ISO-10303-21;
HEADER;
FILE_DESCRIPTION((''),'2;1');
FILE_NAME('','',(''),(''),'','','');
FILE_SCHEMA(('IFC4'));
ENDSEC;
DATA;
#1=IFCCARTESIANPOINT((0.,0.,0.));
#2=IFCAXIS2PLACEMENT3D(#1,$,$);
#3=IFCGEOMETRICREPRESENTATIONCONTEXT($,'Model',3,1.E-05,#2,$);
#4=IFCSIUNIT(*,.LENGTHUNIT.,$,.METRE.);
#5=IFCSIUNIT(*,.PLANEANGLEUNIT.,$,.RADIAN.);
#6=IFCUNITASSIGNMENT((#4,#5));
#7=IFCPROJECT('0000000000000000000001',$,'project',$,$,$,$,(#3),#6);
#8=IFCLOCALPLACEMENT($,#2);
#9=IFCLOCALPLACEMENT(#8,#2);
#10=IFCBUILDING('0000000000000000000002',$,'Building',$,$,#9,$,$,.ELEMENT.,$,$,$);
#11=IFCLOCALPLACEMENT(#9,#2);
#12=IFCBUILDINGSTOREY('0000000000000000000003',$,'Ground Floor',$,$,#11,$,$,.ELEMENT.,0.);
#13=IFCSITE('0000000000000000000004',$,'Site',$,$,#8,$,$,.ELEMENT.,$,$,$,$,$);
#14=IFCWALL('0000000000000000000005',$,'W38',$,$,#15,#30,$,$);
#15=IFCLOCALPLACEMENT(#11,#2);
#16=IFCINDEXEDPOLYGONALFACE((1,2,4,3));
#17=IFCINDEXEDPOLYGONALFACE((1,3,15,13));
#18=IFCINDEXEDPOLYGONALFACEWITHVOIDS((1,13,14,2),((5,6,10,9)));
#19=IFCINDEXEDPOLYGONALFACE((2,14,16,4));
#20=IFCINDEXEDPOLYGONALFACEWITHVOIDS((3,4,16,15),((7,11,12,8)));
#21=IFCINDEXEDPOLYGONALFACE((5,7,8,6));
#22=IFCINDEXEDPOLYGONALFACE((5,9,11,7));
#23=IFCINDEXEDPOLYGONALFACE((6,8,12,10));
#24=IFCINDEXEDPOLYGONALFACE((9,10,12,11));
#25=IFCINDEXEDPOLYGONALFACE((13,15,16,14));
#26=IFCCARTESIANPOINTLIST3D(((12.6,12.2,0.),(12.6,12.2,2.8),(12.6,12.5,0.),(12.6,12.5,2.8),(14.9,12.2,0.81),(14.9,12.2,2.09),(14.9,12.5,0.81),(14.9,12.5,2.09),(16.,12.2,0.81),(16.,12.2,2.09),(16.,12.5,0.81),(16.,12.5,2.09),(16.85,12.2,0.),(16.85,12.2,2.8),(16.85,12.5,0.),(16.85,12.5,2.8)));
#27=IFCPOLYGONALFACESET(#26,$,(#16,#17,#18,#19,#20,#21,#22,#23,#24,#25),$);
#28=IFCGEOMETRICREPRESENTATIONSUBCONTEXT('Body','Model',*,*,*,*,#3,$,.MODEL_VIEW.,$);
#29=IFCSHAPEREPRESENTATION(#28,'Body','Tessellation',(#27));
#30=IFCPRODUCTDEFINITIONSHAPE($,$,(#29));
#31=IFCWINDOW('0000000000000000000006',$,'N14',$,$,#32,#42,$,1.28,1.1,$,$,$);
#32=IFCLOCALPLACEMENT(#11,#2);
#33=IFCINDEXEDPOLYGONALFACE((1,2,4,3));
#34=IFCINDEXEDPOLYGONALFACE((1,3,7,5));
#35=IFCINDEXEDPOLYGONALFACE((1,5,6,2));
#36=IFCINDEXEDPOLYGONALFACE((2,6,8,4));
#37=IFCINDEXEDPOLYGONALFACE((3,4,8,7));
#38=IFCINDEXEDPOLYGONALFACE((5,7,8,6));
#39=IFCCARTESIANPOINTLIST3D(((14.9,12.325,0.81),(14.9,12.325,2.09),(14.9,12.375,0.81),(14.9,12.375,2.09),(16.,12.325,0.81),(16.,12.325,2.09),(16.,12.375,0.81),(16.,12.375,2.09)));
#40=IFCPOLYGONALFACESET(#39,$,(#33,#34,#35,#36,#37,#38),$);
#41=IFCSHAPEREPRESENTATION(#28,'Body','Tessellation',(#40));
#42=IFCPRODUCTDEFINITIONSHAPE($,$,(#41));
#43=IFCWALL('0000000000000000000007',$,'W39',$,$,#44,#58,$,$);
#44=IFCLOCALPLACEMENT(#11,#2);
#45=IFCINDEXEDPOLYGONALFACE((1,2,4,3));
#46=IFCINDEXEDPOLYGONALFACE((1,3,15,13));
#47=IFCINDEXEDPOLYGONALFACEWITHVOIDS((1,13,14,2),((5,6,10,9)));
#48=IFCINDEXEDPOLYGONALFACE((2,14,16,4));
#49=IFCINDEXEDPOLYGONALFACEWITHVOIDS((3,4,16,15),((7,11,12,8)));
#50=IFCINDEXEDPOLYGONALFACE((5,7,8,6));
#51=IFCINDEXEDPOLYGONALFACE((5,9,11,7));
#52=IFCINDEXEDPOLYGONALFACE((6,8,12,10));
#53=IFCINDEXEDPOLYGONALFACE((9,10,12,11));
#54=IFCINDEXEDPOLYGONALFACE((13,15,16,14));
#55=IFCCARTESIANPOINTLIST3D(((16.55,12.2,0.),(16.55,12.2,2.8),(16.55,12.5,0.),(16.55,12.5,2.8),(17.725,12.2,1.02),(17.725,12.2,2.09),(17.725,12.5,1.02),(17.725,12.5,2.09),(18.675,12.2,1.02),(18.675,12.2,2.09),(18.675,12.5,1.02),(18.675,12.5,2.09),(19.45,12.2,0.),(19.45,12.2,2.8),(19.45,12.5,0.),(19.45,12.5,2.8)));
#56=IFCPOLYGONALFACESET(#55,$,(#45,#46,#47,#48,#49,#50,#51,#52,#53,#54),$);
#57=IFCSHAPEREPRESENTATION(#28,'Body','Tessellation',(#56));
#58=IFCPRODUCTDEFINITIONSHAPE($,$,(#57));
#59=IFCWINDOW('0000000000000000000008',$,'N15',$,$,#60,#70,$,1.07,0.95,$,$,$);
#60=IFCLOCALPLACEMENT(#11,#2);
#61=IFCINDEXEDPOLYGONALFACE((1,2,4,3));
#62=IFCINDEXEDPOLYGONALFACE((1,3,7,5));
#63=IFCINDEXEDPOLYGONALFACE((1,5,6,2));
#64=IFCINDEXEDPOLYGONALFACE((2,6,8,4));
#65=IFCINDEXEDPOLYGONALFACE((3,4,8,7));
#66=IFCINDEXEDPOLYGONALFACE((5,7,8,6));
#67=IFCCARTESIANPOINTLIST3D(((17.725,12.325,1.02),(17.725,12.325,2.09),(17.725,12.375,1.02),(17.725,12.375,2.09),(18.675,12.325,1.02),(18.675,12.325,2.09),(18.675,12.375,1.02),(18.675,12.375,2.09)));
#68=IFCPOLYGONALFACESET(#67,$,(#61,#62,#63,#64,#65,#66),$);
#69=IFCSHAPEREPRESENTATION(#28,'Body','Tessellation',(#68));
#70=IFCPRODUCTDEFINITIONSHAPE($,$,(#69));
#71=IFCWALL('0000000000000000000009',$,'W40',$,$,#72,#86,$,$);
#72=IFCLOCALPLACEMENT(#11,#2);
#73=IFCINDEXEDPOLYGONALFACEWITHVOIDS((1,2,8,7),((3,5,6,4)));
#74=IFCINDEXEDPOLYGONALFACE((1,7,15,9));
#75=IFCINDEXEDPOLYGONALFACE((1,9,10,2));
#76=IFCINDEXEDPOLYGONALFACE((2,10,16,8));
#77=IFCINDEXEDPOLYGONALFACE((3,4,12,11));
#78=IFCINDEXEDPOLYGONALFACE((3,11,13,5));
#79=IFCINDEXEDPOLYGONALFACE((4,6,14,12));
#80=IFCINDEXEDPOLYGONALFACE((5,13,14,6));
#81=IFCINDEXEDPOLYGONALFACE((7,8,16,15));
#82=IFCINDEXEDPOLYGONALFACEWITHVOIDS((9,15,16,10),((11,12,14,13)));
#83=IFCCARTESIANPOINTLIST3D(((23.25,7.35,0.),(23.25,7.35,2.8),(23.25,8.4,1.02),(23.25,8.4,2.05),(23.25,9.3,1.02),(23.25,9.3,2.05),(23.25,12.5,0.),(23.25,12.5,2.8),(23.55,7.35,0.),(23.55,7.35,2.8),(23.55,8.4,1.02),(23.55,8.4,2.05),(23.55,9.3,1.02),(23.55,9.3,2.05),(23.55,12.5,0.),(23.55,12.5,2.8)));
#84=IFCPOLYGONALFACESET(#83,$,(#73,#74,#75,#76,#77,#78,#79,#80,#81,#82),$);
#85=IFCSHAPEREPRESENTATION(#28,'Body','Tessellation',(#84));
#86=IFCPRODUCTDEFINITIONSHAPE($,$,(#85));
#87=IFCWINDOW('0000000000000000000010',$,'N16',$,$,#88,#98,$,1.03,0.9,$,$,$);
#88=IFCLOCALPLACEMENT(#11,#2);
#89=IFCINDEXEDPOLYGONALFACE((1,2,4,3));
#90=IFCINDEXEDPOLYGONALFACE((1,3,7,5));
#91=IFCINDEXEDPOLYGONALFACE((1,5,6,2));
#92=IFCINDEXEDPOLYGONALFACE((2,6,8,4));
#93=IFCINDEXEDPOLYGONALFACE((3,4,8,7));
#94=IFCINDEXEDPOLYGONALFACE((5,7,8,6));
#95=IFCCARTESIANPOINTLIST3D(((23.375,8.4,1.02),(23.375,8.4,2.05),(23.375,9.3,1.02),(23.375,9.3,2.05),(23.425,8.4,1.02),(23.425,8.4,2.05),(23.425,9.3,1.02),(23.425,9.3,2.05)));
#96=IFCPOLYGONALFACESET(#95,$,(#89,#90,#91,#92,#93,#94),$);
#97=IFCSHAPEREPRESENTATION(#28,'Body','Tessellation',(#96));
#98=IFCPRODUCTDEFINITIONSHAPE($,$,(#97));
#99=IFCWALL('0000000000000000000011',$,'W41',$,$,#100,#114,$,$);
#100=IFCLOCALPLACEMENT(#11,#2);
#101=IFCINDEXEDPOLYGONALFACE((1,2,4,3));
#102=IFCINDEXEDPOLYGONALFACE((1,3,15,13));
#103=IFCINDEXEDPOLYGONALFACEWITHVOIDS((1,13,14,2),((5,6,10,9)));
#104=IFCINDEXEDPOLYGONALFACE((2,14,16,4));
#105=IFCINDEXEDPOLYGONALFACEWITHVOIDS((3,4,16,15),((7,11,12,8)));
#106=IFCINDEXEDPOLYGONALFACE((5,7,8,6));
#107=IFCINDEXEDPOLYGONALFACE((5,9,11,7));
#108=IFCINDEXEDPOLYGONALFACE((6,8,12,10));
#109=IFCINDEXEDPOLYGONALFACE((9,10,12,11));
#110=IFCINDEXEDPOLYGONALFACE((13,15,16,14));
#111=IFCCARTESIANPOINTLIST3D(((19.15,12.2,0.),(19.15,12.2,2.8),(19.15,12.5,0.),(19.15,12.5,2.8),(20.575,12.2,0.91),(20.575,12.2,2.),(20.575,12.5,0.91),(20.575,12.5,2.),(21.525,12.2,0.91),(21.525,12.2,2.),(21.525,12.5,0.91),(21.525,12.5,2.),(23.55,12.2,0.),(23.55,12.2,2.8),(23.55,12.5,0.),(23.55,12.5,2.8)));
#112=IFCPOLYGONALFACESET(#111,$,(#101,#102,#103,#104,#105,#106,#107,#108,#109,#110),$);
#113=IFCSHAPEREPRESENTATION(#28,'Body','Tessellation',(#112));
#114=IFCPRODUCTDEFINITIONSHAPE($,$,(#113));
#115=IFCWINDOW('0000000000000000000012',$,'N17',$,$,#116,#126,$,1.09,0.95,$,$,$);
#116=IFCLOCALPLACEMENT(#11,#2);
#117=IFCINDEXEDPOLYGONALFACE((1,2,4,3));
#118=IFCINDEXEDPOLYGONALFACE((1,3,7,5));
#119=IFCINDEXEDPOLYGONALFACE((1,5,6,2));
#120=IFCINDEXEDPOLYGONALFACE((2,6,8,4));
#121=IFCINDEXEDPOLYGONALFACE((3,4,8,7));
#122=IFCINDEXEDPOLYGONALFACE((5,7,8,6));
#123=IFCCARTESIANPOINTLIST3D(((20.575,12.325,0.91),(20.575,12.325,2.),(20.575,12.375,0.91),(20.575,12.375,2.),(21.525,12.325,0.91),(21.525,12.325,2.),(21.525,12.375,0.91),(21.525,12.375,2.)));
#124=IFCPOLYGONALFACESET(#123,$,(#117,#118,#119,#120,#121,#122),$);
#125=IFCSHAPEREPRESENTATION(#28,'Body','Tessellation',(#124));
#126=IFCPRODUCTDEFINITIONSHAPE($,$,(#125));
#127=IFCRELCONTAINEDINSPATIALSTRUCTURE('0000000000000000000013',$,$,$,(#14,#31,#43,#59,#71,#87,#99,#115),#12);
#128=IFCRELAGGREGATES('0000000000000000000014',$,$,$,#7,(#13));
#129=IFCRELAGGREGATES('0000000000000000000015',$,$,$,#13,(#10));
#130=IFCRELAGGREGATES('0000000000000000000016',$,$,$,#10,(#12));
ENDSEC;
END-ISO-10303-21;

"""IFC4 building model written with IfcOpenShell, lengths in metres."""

from ifc_helpers import new_model, si_unit, frame, frame_2d, origin, origin_2d, place, context, subcontext, project, spatial, rectangle, extrude, element, fill, save


model = new_model("IFC4")

# Units and contexts
model_context = context("Model", 3, precision=1e-05, world=origin())
body_context = subcontext(model_context, "Body", "Model", "MODEL_VIEW")
ifc_project = project(units=[si_unit("LENGTHUNIT", "METRE"), si_unit("PLANEANGLEUNIT", "RADIAN")], contexts=[model_context])

# Site, building, storey
site_placement = place(None, origin())
site = spatial("IfcSite", under=ifc_project, at=site_placement, Name="Site", CompositionType="ELEMENT")
building_placement = place(site_placement, origin())
building = spatial("IfcBuilding", under=site, at=building_placement, Name="Building", CompositionType="ELEMENT")
storey_placement = place(building_placement, origin())
storey = spatial("IfcBuildingStorey", under=building, at=storey_placement, Name="Ground Floor", CompositionType="ELEMENT", Elevation=0.0)

# Walls, openings, windows
wall_1_placement = place(storey_placement, frame((12.75, 12.35, 0.0), x_axis=(1.0, 0.0, 0.0)))
wall_1 = element("IfcWall", 1, at=wall_1_placement, inside=storey, Name="W38", context=body_context, shape_type="SweptSolid", body=[
    extrude(rectangle(XDim=4.25, YDim=0.3, at=frame_2d((1.975, 0.0))), origin(), (0.0, 0.0, 1.0), 2.8),
])
opening_1_placement = place(wall_1_placement, frame((2.7, 0.0, 0.81)))
opening_1 = element("IfcOpeningElement", 2, at=opening_1_placement, cuts=wall_1, context=body_context, shape_type="SweptSolid", body=[
    extrude(rectangle(XDim=1.1, YDim=0.4, at=origin_2d()), origin(), (0.0, 0.0, 1.0), 1.28),
])
window_1_placement = place(opening_1_placement, origin())
window_1 = element("IfcWindow", 3, at=window_1_placement, inside=storey, Name="N14", OverallHeight=1.28, OverallWidth=1.1, context=body_context, shape_type="SweptSolid", body=[
    extrude(rectangle(XDim=1.1, YDim=0.05, at=origin_2d()), origin(), (0.0, 0.0, 1.0), 1.28),
])
fill(opening_1, window_1)
wall_2_placement = place(storey_placement, frame((16.7, 12.35, 0.0), x_axis=(1.0, 0.0, 0.0)))
wall_2 = element("IfcWall", 4, at=wall_2_placement, inside=storey, Name="W39", context=body_context, shape_type="SweptSolid", body=[
    extrude(rectangle(XDim=2.9, YDim=0.3, at=frame_2d((1.3, 0.0))), origin(), (0.0, 0.0, 1.0), 2.8),
])
opening_2_placement = place(wall_2_placement, frame((1.5, 0.0, 1.02)))
opening_2 = element("IfcOpeningElement", 5, at=opening_2_placement, cuts=wall_2, context=body_context, shape_type="SweptSolid", body=[
    extrude(rectangle(XDim=0.95, YDim=0.4, at=origin_2d()), origin(), (0.0, 0.0, 1.0), 1.07),
])
window_2_placement = place(opening_2_placement, origin())
window_2 = element("IfcWindow", 6, at=window_2_placement, inside=storey, Name="N15", OverallHeight=1.07, OverallWidth=0.95, context=body_context, shape_type="SweptSolid", body=[
    extrude(rectangle(XDim=0.95, YDim=0.05, at=origin_2d()), origin(), (0.0, 0.0, 1.0), 1.07),
])
fill(opening_2, window_2)
wall_3_placement = place(storey_placement, frame((23.4, 7.5, 0.0), x_axis=(0.0, 1.0, 0.0)))
wall_3 = element("IfcWall", 7, at=wall_3_placement, inside=storey, Name="W40", context=body_context, shape_type="SweptSolid", body=[
    extrude(rectangle(XDim=5.15, YDim=0.3, at=frame_2d((2.425, 0.0))), origin(), (0.0, 0.0, 1.0), 2.8),
])
opening_3_placement = place(wall_3_placement, frame((1.35, 0.0, 1.02)))
opening_3 = element("IfcOpeningElement", 8, at=opening_3_placement, cuts=wall_3, context=body_context, shape_type="SweptSolid", body=[
    extrude(rectangle(XDim=0.9, YDim=0.4, at=origin_2d()), origin(), (0.0, 0.0, 1.0), 1.03),
])
window_3_placement = place(opening_3_placement, origin())
window_3 = element("IfcWindow", 9, at=window_3_placement, inside=storey, Name="N16", OverallHeight=1.03, OverallWidth=0.9, context=body_context, shape_type="SweptSolid", body=[
    extrude(rectangle(XDim=0.9, YDim=0.05, at=origin_2d()), origin(), (0.0, 0.0, 1.0), 1.03),
])
fill(opening_3, window_3)
wall_4_placement = place(storey_placement, frame((19.3, 12.35, 0.0), x_axis=(1.0, 0.0, 0.0)))
wall_4 = element("IfcWall", 10, at=wall_4_placement, inside=storey, Name="W41", context=body_context, shape_type="SweptSolid", body=[
    extrude(rectangle(XDim=4.4, YDim=0.3, at=frame_2d((2.05, 0.0))), origin(), (0.0, 0.0, 1.0), 2.8),
])
opening_4_placement = place(wall_4_placement, frame((1.75, 0.0, 0.91)))
opening_4 = element("IfcOpeningElement", 11, at=opening_4_placement, cuts=wall_4, context=body_context, shape_type="SweptSolid", body=[
    extrude(rectangle(XDim=0.95, YDim=0.4, at=origin_2d()), origin(), (0.0, 0.0, 1.0), 1.09),
])
window_4_placement = place(opening_4_placement, origin())
window_4 = element("IfcWindow", 12, at=window_4_placement, inside=storey, Name="N17", OverallHeight=1.09, OverallWidth=0.95, context=body_context, shape_type="SweptSolid", body=[
    extrude(rectangle(XDim=0.95, YDim=0.05, at=origin_2d()), origin(), (0.0, 0.0, 1.0), 1.09),
])
fill(opening_4, window_4)

save(model, "model.ifc")
